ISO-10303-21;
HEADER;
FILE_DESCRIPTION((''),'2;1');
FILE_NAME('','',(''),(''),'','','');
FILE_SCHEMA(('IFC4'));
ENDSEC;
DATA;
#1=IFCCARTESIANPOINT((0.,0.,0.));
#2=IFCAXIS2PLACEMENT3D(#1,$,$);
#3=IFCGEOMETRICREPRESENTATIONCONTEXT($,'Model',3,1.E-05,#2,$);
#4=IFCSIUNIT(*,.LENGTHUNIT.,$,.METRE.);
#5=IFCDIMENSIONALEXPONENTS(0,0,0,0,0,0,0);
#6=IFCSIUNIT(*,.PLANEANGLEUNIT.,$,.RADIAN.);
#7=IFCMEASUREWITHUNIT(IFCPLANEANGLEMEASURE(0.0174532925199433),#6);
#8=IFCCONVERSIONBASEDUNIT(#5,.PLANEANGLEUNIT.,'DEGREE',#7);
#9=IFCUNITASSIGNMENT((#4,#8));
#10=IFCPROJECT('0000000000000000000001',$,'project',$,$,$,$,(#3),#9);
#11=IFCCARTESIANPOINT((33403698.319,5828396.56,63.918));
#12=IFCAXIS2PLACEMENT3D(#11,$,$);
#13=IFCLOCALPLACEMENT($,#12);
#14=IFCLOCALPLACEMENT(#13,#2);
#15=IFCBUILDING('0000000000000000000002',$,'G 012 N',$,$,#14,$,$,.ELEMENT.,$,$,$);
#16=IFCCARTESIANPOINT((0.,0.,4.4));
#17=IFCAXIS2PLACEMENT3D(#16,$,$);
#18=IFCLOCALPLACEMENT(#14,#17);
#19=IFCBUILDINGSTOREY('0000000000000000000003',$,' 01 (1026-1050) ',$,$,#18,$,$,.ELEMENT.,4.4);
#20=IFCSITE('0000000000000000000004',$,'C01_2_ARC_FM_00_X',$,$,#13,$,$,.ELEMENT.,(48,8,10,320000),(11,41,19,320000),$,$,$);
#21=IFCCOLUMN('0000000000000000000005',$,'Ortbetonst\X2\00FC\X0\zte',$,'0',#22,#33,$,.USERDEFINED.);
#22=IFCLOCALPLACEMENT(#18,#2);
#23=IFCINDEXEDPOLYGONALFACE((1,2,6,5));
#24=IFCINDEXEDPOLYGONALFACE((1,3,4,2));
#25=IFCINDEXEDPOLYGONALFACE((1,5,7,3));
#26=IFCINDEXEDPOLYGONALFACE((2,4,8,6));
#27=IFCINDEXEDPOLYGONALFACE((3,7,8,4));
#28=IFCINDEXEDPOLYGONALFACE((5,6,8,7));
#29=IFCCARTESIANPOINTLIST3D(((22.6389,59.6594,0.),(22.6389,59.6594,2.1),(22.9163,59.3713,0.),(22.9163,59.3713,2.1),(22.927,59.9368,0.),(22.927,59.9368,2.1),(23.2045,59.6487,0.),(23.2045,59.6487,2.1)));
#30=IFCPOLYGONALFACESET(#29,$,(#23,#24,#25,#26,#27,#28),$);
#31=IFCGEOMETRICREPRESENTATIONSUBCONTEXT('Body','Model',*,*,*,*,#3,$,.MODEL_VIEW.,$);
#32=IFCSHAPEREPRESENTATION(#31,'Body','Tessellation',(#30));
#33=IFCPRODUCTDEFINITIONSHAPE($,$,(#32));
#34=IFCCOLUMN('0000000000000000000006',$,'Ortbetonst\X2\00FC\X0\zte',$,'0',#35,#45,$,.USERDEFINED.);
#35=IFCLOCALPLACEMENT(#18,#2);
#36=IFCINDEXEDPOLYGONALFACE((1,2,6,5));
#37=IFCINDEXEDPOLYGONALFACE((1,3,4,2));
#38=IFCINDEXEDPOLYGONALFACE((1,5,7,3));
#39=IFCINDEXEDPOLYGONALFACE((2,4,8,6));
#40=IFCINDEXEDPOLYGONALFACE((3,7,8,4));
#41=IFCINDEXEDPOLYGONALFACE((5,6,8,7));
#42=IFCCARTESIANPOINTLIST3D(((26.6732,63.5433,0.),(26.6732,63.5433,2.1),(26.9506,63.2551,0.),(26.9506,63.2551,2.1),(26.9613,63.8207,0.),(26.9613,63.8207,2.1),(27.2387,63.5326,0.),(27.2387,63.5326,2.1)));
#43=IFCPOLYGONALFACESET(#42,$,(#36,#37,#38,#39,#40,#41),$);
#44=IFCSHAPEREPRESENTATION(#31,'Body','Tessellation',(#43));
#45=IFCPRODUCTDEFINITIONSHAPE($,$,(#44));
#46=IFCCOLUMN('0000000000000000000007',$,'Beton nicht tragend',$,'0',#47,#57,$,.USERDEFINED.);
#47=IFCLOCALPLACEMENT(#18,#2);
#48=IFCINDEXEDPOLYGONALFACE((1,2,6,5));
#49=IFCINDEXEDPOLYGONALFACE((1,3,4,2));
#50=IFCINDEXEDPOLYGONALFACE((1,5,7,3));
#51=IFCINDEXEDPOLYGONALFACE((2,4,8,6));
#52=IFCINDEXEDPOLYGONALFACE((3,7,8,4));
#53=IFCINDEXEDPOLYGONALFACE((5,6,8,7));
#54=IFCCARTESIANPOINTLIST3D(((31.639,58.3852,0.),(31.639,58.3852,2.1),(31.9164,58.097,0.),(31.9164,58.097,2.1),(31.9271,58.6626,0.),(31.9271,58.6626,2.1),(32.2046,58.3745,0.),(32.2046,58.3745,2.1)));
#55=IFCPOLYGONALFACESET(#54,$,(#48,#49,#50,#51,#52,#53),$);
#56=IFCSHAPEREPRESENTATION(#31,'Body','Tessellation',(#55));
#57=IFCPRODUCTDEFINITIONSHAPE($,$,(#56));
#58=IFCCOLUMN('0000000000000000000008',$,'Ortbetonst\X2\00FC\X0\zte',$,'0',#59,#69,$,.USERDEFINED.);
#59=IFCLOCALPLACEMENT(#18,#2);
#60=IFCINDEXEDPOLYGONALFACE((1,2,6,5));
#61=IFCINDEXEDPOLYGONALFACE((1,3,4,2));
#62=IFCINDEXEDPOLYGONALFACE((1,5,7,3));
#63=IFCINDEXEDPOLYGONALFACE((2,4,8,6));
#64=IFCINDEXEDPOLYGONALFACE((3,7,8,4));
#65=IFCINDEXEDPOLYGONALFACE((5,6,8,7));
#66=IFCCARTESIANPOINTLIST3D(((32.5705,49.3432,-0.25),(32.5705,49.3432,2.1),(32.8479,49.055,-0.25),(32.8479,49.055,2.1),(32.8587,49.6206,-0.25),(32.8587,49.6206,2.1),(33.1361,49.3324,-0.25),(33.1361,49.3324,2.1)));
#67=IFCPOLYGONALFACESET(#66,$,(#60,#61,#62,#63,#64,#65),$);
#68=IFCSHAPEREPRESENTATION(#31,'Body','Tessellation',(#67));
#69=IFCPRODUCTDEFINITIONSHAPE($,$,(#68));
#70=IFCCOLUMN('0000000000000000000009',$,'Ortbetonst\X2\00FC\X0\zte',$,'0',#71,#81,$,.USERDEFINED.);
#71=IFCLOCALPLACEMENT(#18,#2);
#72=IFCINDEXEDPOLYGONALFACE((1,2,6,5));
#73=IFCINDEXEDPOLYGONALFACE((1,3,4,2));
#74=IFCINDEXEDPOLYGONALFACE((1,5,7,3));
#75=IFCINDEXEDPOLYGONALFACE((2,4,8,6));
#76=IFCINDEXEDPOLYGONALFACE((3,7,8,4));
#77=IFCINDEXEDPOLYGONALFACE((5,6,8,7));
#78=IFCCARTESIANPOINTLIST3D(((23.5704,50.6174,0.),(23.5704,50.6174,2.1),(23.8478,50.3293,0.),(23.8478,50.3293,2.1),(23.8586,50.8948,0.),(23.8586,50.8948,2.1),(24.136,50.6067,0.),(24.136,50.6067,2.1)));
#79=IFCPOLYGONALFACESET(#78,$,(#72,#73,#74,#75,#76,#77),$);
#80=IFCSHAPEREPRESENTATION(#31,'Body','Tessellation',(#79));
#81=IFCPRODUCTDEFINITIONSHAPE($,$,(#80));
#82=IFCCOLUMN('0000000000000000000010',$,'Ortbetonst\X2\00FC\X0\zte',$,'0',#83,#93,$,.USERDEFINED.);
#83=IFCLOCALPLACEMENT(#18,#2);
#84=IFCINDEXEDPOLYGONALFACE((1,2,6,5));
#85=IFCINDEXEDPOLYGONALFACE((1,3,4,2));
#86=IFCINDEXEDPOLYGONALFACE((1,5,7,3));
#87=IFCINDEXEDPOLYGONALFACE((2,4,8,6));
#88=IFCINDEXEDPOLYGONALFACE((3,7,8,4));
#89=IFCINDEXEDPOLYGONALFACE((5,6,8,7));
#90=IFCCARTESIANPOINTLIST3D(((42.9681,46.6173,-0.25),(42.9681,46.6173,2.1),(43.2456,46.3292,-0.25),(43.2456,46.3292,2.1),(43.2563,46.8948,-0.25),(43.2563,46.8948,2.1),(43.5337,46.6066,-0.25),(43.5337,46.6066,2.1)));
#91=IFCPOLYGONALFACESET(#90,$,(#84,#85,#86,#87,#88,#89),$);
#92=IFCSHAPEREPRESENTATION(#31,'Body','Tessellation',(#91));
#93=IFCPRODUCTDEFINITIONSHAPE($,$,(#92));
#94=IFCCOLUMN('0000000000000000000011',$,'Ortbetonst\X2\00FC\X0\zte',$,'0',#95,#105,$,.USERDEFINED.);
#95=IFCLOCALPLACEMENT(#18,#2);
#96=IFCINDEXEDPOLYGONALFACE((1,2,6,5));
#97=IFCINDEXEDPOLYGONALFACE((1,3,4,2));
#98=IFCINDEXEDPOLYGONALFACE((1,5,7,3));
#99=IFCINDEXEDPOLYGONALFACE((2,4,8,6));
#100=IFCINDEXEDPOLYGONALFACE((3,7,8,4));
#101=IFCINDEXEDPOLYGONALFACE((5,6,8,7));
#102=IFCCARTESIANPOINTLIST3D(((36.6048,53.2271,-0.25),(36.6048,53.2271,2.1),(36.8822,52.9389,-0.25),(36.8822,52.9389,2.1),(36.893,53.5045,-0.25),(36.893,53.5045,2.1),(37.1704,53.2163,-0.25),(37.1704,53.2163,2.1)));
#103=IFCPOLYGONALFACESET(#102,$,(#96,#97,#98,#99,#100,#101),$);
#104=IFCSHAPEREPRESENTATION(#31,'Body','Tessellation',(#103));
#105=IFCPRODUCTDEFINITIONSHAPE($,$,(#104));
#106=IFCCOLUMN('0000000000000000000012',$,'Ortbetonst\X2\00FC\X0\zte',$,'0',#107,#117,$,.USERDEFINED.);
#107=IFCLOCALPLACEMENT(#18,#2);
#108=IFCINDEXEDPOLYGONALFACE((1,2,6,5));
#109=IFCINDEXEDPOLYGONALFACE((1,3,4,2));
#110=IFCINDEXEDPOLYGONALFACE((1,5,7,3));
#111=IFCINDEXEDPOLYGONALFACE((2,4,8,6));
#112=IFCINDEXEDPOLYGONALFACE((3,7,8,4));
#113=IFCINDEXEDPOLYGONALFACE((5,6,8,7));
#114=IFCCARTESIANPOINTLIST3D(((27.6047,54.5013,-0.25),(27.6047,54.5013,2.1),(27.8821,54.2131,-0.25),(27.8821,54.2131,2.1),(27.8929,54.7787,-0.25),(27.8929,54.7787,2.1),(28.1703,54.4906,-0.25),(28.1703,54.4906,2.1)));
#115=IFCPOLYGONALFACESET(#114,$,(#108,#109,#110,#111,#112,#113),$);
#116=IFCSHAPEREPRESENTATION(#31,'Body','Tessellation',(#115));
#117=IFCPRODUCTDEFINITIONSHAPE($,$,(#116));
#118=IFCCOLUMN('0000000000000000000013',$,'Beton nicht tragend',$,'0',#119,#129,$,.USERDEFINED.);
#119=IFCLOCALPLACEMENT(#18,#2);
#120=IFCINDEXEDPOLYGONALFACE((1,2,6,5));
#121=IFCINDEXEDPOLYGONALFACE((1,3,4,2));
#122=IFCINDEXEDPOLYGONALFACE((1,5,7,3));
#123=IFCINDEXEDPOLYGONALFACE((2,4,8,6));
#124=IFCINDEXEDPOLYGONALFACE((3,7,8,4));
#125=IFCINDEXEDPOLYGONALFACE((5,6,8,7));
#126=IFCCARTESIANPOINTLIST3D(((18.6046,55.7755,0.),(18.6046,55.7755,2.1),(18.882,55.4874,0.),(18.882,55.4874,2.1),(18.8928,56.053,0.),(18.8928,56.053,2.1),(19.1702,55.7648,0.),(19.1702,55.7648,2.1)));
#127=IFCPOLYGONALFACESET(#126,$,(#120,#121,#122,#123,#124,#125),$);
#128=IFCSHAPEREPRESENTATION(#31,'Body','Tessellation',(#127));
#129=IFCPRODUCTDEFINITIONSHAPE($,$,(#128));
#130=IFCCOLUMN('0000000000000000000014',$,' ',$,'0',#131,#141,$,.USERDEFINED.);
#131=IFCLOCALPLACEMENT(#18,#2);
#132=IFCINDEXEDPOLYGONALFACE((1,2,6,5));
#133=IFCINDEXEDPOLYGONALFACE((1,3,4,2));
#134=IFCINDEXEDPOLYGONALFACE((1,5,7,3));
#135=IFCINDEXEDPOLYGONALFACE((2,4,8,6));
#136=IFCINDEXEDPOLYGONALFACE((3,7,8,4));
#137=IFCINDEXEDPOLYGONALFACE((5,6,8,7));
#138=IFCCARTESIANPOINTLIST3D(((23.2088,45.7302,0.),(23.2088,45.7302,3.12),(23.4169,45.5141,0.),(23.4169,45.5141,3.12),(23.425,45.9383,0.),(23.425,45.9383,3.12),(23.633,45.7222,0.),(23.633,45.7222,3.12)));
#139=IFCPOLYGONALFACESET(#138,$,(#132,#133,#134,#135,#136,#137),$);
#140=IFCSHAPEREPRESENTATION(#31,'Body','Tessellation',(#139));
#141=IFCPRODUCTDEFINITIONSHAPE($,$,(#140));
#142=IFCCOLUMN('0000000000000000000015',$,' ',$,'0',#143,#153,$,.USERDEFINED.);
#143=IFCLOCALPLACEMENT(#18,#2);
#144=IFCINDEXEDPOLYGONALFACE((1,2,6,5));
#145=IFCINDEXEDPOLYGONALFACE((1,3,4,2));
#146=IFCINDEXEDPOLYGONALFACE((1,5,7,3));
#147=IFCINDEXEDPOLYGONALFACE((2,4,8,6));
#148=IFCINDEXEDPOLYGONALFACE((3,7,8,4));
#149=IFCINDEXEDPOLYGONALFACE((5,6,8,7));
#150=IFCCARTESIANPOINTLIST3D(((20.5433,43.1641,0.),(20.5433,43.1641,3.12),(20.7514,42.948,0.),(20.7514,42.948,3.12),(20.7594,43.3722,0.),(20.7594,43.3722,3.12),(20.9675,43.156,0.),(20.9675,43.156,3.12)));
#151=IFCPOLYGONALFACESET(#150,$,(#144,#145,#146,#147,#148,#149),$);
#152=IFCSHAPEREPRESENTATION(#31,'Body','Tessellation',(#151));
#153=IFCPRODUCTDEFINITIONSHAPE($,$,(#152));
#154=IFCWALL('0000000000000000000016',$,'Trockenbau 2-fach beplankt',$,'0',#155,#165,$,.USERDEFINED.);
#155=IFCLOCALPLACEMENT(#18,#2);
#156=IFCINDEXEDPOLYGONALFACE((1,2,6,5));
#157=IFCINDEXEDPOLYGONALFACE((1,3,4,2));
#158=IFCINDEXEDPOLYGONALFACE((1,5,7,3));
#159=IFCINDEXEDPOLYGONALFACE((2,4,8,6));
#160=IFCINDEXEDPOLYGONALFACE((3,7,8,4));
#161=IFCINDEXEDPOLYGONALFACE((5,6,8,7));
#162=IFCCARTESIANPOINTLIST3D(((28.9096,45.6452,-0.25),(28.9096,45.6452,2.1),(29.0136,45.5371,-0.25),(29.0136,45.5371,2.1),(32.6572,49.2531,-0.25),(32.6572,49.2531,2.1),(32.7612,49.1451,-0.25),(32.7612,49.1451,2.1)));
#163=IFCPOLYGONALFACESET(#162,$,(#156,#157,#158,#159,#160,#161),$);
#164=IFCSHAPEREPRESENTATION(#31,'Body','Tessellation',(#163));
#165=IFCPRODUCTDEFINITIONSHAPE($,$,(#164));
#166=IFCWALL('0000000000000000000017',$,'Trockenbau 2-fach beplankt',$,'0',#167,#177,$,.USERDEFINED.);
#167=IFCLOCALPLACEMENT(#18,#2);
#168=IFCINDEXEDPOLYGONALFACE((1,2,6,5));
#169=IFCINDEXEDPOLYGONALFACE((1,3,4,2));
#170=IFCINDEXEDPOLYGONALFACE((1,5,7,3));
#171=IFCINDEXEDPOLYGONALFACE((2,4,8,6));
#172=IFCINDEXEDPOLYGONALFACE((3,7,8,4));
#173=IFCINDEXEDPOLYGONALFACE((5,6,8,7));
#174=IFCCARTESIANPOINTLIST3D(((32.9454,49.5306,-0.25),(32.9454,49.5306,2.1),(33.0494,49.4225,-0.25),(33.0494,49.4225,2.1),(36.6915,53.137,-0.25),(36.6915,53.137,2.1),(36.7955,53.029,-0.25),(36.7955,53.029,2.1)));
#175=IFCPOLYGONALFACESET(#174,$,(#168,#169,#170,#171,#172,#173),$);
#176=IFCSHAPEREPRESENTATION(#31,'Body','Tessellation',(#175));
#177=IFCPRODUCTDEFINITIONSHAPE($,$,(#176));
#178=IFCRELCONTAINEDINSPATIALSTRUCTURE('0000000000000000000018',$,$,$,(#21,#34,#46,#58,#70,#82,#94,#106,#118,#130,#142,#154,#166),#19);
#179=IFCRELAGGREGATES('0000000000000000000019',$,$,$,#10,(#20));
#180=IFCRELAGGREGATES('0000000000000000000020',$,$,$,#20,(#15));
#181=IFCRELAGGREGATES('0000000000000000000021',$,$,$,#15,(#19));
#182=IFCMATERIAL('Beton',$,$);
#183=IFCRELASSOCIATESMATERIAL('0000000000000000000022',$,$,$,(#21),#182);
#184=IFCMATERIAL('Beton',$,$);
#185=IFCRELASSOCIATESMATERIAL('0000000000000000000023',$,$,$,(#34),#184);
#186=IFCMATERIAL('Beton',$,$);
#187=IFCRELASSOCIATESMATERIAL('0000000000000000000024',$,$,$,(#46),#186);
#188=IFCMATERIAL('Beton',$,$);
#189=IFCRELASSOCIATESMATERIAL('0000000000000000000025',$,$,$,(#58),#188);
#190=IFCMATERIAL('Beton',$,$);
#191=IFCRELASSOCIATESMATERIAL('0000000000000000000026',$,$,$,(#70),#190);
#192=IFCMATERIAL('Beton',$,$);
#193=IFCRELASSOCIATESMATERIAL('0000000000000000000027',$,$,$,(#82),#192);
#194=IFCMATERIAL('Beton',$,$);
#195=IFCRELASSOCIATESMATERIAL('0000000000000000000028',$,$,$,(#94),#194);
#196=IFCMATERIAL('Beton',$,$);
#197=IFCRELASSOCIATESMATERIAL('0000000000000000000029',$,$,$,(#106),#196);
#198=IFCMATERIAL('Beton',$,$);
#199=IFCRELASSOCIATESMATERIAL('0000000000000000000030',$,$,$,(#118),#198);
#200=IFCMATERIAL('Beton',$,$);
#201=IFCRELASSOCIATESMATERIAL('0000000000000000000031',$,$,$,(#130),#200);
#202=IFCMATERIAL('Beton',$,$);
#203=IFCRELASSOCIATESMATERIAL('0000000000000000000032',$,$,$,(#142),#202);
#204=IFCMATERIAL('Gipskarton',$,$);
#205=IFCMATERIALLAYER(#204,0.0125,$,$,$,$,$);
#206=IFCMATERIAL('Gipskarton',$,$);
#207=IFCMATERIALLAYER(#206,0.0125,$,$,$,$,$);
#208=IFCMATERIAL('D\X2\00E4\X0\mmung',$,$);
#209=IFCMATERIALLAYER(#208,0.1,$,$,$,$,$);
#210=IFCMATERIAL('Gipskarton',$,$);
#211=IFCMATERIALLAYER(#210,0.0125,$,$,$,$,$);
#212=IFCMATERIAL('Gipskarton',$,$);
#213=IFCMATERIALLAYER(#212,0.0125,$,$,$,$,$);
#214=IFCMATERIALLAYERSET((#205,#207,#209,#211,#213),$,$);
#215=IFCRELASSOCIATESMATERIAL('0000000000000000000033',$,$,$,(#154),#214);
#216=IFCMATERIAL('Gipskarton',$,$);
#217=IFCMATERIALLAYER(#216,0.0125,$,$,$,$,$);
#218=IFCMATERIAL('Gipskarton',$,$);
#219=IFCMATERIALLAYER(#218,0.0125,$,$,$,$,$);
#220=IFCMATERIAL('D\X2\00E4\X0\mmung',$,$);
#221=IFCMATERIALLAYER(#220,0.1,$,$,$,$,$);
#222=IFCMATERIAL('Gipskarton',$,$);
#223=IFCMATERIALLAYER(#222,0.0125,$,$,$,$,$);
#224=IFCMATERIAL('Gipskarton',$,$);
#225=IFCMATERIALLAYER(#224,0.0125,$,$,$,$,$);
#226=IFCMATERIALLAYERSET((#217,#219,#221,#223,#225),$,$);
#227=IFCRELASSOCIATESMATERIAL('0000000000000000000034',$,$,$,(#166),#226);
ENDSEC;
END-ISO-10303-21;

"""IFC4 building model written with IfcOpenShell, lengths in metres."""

from ifc_helpers import new_model, entity, si_unit, converted_unit, frame, frame_2d, origin, origin_with_axes, place, context, subcontext, project, spatial, rectangle, extrude, material, layer, layer_set, layer_usage, element, save


model = new_model("IFC4")

# Units and contexts
model_context = context("Model", 3, precision=1e-05, world=origin())
body_context = subcontext(model_context, "Body", "Model", "MODEL_VIEW")
ifc_project = project(units=[si_unit("LENGTHUNIT", "METRE"), converted_unit("PLANEANGLEUNIT", "DEGREE", entity("IfcPlaneAngleMeasure", 0.0174532925199433), si_unit("PLANEANGLEUNIT", "RADIAN"), dimensions=[0, 0, 0, 0, 0, 0, 0])], contexts=[model_context])

# Site, building, storey
site_placement = place(None, frame((33403698.319, 5828396.56, 63.918)))
site = spatial("IfcSite", under=ifc_project, at=site_placement, Name="C01_2_ARC_FM_00_X", CompositionType="ELEMENT", RefLatitude=(48, 8, 10, 320000), RefLongitude=(11, 41, 19, 320000))
building_placement = place(site_placement, origin())
building = spatial("IfcBuilding", under=site, at=building_placement, Name="G 012 N", CompositionType="ELEMENT")
storey_placement = place(building_placement, frame((0.0, 0.0, 4.4)))
storey = spatial("IfcBuildingStorey", under=building, at=storey_placement, Name=" 01 (1026-1050) ", CompositionType="ELEMENT", Elevation=4.4)

# Columns
ifc_material_1 = material(Name="Beton")
column_1_placement = place(storey_placement, frame((22.9163, 59.3713, 0.0)))
element("IfcColumn", 1, at=column_1_placement, inside=storey, material=ifc_material_1, Name="Ortbetonstüzte", ObjectType="0", PredefinedType="USERDEFINED", context=body_context, shape_type="SweptSolid", body=[
    extrude(rectangle(XDim=0.4, YDim=0.4, at=frame_2d((0.0054, 0.2828), x_axis=(0.720408, 0.693551))), origin_with_axes(), (0.0, 0.0, 1.0), 2.1),
])
ifc_material_2 = material(Name="Beton")
column_2_placement = place(storey_placement, frame((26.9506, 63.2551, 0.0)))
element("IfcColumn", 2, at=column_2_placement, inside=storey, material=ifc_material_2, Name="Ortbetonstüzte", ObjectType="0", PredefinedType="USERDEFINED", context=body_context, shape_type="SweptSolid", body=[
    extrude(rectangle(XDim=0.4, YDim=0.4, at=frame_2d((0.0054, 0.2828), x_axis=(0.720408, 0.693551))), origin_with_axes(), (0.0, 0.0, 1.0), 2.1),
])
ifc_material_3 = material(Name="Beton")
column_3_placement = place(storey_placement, frame((31.9164, 58.097, 0.0)))
element("IfcColumn", 3, at=column_3_placement, inside=storey, material=ifc_material_3, Name="Beton nicht tragend", ObjectType="0", PredefinedType="USERDEFINED", context=body_context, shape_type="SweptSolid", body=[
    extrude(rectangle(XDim=0.4, YDim=0.4, at=frame_2d((0.0054, 0.2828), x_axis=(0.720408, 0.693551))), origin_with_axes(), (0.0, 0.0, 1.0), 2.1),
])
ifc_material_4 = material(Name="Beton")
column_4_placement = place(storey_placement, frame((32.8479, 49.055, -0.25)))
element("IfcColumn", 4, at=column_4_placement, inside=storey, material=ifc_material_4, Name="Ortbetonstüzte", ObjectType="0", PredefinedType="USERDEFINED", context=body_context, shape_type="SweptSolid", body=[
    extrude(rectangle(XDim=0.4, YDim=0.4, at=frame_2d((0.0054, 0.2828), x_axis=(0.720408, 0.693551))), origin_with_axes(), (0.0, 0.0, 1.0), 2.35),
])
ifc_material_5 = material(Name="Beton")
column_5_placement = place(storey_placement, frame((23.8478, 50.3293, 0.0)))
element("IfcColumn", 5, at=column_5_placement, inside=storey, material=ifc_material_5, Name="Ortbetonstüzte", ObjectType="0", PredefinedType="USERDEFINED", context=body_context, shape_type="SweptSolid", body=[
    extrude(rectangle(XDim=0.4, YDim=0.4, at=frame_2d((0.0054, 0.2828), x_axis=(0.720408, 0.693551))), origin_with_axes(), (0.0, 0.0, 1.0), 2.1),
])
ifc_material_6 = material(Name="Beton")
column_6_placement = place(storey_placement, frame((43.2456, 46.3292, -0.25)))
element("IfcColumn", 6, at=column_6_placement, inside=storey, material=ifc_material_6, Name="Ortbetonstüzte", ObjectType="0", PredefinedType="USERDEFINED", context=body_context, shape_type="SweptSolid", body=[
    extrude(rectangle(XDim=0.4, YDim=0.4, at=frame_2d((0.0054, 0.2828), x_axis=(0.720408, 0.693551))), origin_with_axes(), (0.0, 0.0, 1.0), 2.35),
])
ifc_material_7 = material(Name="Beton")
column_7_placement = place(storey_placement, frame((36.8822, 52.9389, -0.25)))
element("IfcColumn", 7, at=column_7_placement, inside=storey, material=ifc_material_7, Name="Ortbetonstüzte", ObjectType="0", PredefinedType="USERDEFINED", context=body_context, shape_type="SweptSolid", body=[
    extrude(rectangle(XDim=0.4, YDim=0.4, at=frame_2d((0.0054, 0.2828), x_axis=(0.720408, 0.693551))), origin_with_axes(), (0.0, 0.0, 1.0), 2.35),
])
ifc_material_8 = material(Name="Beton")
column_8_placement = place(storey_placement, frame((27.8821, 54.2131, -0.25)))
element("IfcColumn", 8, at=column_8_placement, inside=storey, material=ifc_material_8, Name="Ortbetonstüzte", ObjectType="0", PredefinedType="USERDEFINED", context=body_context, shape_type="SweptSolid", body=[
    extrude(rectangle(XDim=0.4, YDim=0.4, at=frame_2d((0.0054, 0.2828), x_axis=(0.720408, 0.693551))), origin_with_axes(), (0.0, 0.0, 1.0), 2.35),
])
ifc_material_9 = material(Name="Beton")
column_9_placement = place(storey_placement, frame((18.882, 55.4874, 0.0)))
element("IfcColumn", 9, at=column_9_placement, inside=storey, material=ifc_material_9, Name="Beton nicht tragend", ObjectType="0", PredefinedType="USERDEFINED", context=body_context, shape_type="SweptSolid", body=[
    extrude(rectangle(XDim=0.4, YDim=0.4, at=frame_2d((0.0054, 0.2828), x_axis=(0.720408, 0.693551))), origin_with_axes(), (0.0, 0.0, 1.0), 2.1),
])
ifc_material_10 = material(Name="Beton")
column_10_placement = place(storey_placement, frame((23.4169, 45.5141, 0.0)))
element("IfcColumn", 10, at=column_10_placement, inside=storey, material=ifc_material_10, Name=" ", ObjectType="0", PredefinedType="USERDEFINED", context=body_context, shape_type="SweptSolid", body=[
    extrude(rectangle(XDim=0.3, YDim=0.3, at=frame_2d((0.004, 0.2121), x_axis=(0.720408, 0.693551))), origin_with_axes(), (0.0, 0.0, 1.0), 3.12),
])
ifc_material_11 = material(Name="Beton")
column_11_placement = place(storey_placement, frame((20.7514, 42.948, 0.0)))
element("IfcColumn", 11, at=column_11_placement, inside=storey, material=ifc_material_11, Name=" ", ObjectType="0", PredefinedType="USERDEFINED", context=body_context, shape_type="SweptSolid", body=[
    extrude(rectangle(XDim=0.3, YDim=0.3, at=frame_2d((0.004, 0.2121), x_axis=(0.720408, 0.693551))), origin_with_axes(), (0.0, 0.0, 1.0), 3.12),
])

# Walls
ifc_material_12 = material(Name="Gipskarton")
ifc_layer_1 = layer(ifc_material_12, 0.0125)
ifc_material_13 = material(Name="Gipskarton")
ifc_layer_2 = layer(ifc_material_13, 0.0125)
ifc_material_14 = material(Name="Dämmung")
ifc_layer_3 = layer(ifc_material_14, 0.1)
ifc_material_15 = material(Name="Gipskarton")
ifc_layer_4 = layer(ifc_material_15, 0.0125)
ifc_material_16 = material(Name="Gipskarton")
ifc_layer_5 = layer(ifc_material_16, 0.0125)
ifc_layer_set_1 = layer_set([ifc_layer_1, ifc_layer_2, ifc_layer_3, ifc_layer_4, ifc_layer_5])
ifc_layer_usage_1 = layer_usage(ifc_layer_set_1, "AXIS2", "POSITIVE", 0.0)
wall_1_placement = place(storey_placement, frame((32.6572, 49.2531, -0.25), z_axis=(0.0, 0.0, 1.0), x_axis=(-0.720408, -0.693551, 0.0)))
element("IfcWall", 12, at=wall_1_placement, inside=storey, material=ifc_layer_usage_1, Name="Trockenbau 2-fach beplankt", ObjectType="0", PredefinedType="USERDEFINED", context=body_context, shape_type="SweptSolid", body=[
    extrude(rectangle(XDim=5.2021, YDim=0.15, at=frame_2d((2.6011, 0.075), x_axis=(1.0, 0.0))), origin_with_axes(), (0.0, 0.0, 1.0), 2.35),
])
ifc_material_17 = material(Name="Gipskarton")
ifc_layer_6 = layer(ifc_material_17, 0.0125)
ifc_material_18 = material(Name="Gipskarton")
ifc_layer_7 = layer(ifc_material_18, 0.0125)
ifc_material_19 = material(Name="Dämmung")
ifc_layer_8 = layer(ifc_material_19, 0.1)
ifc_material_20 = material(Name="Gipskarton")
ifc_layer_9 = layer(ifc_material_20, 0.0125)
ifc_material_21 = material(Name="Gipskarton")
ifc_layer_10 = layer(ifc_material_21, 0.0125)
ifc_layer_set_2 = layer_set([ifc_layer_6, ifc_layer_7, ifc_layer_8, ifc_layer_9, ifc_layer_10])
ifc_layer_usage_2 = layer_usage(ifc_layer_set_2, "AXIS2", "POSITIVE", 0.0)
wall_2_placement = place(storey_placement, frame((36.6915, 53.137, -0.25), z_axis=(0.0, 0.0, 1.0), x_axis=(-0.720408, -0.693551, 0.0)))
element("IfcWall", 13, at=wall_2_placement, inside=storey, material=ifc_layer_usage_2, Name="Trockenbau 2-fach beplankt", ObjectType="0", PredefinedType="USERDEFINED", context=body_context, shape_type="SweptSolid", body=[
    extrude(rectangle(XDim=5.2, YDim=0.15, at=frame_2d((2.6, 0.075), x_axis=(1.0, 0.0))), origin_with_axes(), (0.0, 0.0, 1.0), 2.35),
])

save(model, "model.ifc")
